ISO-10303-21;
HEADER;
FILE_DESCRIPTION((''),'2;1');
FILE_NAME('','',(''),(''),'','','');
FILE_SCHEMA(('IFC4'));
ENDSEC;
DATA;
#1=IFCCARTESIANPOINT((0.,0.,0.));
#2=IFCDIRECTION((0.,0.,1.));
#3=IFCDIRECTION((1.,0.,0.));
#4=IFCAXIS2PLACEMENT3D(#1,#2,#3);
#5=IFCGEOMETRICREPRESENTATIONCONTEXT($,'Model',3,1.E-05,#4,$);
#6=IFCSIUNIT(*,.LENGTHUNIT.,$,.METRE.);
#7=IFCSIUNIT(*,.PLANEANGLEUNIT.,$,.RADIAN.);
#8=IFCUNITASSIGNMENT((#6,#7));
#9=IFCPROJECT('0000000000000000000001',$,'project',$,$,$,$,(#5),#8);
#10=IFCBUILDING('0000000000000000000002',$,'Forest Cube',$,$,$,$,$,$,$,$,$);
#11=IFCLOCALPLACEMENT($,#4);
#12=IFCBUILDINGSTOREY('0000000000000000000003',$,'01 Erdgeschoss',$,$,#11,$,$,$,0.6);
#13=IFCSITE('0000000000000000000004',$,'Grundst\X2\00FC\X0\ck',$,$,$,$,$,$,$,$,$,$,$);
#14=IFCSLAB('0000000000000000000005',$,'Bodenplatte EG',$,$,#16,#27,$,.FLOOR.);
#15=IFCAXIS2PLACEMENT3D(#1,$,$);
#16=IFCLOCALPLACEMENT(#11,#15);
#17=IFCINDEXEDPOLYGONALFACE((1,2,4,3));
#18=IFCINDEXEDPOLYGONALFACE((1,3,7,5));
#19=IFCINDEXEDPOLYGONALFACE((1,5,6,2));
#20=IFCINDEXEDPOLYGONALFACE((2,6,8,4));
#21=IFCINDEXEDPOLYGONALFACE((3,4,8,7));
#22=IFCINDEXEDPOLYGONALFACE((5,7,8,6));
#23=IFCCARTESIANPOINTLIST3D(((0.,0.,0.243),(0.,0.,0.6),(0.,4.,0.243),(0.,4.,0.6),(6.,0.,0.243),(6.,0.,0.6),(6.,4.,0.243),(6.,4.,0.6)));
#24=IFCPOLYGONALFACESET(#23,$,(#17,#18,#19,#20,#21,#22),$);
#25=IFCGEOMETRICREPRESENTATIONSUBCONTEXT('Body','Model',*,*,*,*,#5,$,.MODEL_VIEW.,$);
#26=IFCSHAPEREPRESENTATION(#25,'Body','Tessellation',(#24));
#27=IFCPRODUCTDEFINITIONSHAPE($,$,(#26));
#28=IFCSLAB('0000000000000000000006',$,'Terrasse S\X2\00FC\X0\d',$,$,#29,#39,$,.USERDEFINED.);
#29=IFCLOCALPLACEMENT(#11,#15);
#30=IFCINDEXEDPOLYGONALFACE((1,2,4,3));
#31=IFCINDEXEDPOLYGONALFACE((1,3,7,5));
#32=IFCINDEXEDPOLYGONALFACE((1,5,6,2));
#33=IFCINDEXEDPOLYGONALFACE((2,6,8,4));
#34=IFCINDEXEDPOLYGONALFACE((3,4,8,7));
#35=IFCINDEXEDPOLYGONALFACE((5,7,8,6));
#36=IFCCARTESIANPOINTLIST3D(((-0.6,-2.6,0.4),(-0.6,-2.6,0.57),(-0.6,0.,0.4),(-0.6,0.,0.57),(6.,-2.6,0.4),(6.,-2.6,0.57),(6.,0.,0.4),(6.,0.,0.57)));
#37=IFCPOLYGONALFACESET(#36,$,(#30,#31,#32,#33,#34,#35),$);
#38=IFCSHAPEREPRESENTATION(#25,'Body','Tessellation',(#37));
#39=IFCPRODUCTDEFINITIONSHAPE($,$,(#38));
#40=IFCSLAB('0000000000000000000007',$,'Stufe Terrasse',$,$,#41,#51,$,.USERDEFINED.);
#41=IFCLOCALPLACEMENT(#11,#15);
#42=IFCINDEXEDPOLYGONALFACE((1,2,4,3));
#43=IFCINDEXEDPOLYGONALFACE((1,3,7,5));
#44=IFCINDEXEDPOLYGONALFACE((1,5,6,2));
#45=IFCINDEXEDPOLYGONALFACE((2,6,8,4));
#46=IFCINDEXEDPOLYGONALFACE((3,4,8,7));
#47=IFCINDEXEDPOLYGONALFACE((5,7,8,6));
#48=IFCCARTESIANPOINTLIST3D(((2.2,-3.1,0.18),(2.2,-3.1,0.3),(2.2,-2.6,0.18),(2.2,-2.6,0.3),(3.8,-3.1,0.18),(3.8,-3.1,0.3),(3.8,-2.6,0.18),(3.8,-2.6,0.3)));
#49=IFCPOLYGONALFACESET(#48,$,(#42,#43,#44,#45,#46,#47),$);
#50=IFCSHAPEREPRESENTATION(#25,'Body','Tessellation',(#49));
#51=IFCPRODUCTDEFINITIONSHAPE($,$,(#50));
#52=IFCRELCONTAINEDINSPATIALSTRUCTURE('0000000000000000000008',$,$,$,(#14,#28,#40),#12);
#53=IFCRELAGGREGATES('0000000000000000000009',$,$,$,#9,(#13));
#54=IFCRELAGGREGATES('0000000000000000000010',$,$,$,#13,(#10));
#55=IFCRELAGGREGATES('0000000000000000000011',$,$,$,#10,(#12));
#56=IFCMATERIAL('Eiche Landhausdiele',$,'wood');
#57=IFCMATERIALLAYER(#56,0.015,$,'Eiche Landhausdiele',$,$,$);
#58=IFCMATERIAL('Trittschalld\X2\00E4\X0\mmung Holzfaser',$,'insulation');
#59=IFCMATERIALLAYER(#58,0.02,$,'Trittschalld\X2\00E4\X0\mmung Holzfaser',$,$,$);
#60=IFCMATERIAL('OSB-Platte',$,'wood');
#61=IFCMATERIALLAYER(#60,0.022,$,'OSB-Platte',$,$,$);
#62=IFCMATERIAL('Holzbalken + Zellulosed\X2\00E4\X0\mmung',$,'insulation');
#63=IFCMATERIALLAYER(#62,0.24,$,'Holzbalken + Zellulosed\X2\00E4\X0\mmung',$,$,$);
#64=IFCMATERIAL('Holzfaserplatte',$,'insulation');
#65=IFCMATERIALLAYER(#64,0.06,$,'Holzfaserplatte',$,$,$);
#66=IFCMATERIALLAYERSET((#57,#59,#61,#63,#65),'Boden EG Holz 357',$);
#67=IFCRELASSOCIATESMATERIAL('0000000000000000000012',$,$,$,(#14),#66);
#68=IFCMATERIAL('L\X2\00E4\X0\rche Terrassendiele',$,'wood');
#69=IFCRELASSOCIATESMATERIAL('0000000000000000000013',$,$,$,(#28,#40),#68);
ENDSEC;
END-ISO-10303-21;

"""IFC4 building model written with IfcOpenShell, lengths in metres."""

from ifc_helpers import new_model, si_unit, frame, origin_with_axes, place, context, subcontext, project, spatial, indexed_curve, outline, extrude, material, layer, layer_set, element, save


model = new_model("IFC4")

# Units and contexts
model_context = context("Model", 3, precision=1e-05, world=origin_with_axes())
body_context = subcontext(model_context, "Body", "Model", "MODEL_VIEW")
ifc_project = project(units=[si_unit("LENGTHUNIT", "METRE"), si_unit("PLANEANGLEUNIT", "RADIAN")], contexts=[model_context])

# Site, building, storey
site = spatial("IfcSite", under=ifc_project, Name="Grundstück")
building = spatial("IfcBuilding", under=site, Name="Forest Cube")
storey_placement = place(None, origin_with_axes())
storey = spatial("IfcBuildingStorey", under=building, at=storey_placement, Name="01 Erdgeschoss", Elevation=0.6)

# Slabs
ifc_material_1 = material(Name="Eiche Landhausdiele", Category="wood")
ifc_layer_1 = layer(ifc_material_1, 0.015, Name="Eiche Landhausdiele")
ifc_material_2 = material(Name="Trittschalldämmung Holzfaser", Category="insulation")
ifc_layer_2 = layer(ifc_material_2, 0.02, Name="Trittschalldämmung Holzfaser")
ifc_material_3 = material(Name="OSB-Platte", Category="wood")
ifc_layer_3 = layer(ifc_material_3, 0.022, Name="OSB-Platte")
ifc_material_4 = material(Name="Holzbalken + Zellulosedämmung", Category="insulation")
ifc_layer_4 = layer(ifc_material_4, 0.24, Name="Holzbalken + Zellulosedämmung")
ifc_material_5 = material(Name="Holzfaserplatte", Category="insulation")
ifc_layer_5 = layer(ifc_material_5, 0.06, Name="Holzfaserplatte")
ifc_layer_set_1 = layer_set([ifc_layer_1, ifc_layer_2, ifc_layer_3, ifc_layer_4, ifc_layer_5], Name="Boden EG Holz 357")
slab_1_placement = place(storey_placement, frame((0.0, 0.0, 0.243), z_axis=(0.0, 0.0, 1.0), x_axis=(1.0, 0.0, 0.0)))
element("IfcSlab", 1, at=slab_1_placement, inside=storey, material=ifc_layer_set_1, Name="Bodenplatte EG", PredefinedType="FLOOR", context=body_context, shape_type="SweptSolid", body=[
    extrude(outline(indexed_curve([(0.0, 0.0), (6.0, 0.0), (6.0, 4.0), (0.0, 4.0)])), None, (0.0, 0.0, 1.0), 0.357),
])
ifc_material_6 = material(Name="Lärche Terrassendiele", Category="wood")
slab_2_placement = place(storey_placement, frame((0.0, 0.0, 0.4), z_axis=(0.0, 0.0, 1.0), x_axis=(1.0, 0.0, 0.0)))
element("IfcSlab", 2, at=slab_2_placement, inside=storey, material=ifc_material_6, Name="Terrasse Süd", PredefinedType="USERDEFINED", context=body_context, shape_type="SweptSolid", body=[
    extrude(outline(indexed_curve([(-0.6, -2.6), (6.0, -2.6), (6.0, 0.0), (-0.6, 0.0)])), None, (0.0, 0.0, 1.0), 0.17),
])
slab_3_placement = place(storey_placement, frame((0.0, 0.0, 0.18), z_axis=(0.0, 0.0, 1.0), x_axis=(1.0, 0.0, 0.0)))
element("IfcSlab", 3, at=slab_3_placement, inside=storey, material=ifc_material_6, Name="Stufe Terrasse", PredefinedType="USERDEFINED", context=body_context, shape_type="SweptSolid", body=[
    extrude(outline(indexed_curve([(2.2, -3.1), (3.8, -3.1), (3.8, -2.6), (2.2, -2.6)])), None, (0.0, 0.0, 1.0), 0.12),
])

save(model, "model.ifc")
